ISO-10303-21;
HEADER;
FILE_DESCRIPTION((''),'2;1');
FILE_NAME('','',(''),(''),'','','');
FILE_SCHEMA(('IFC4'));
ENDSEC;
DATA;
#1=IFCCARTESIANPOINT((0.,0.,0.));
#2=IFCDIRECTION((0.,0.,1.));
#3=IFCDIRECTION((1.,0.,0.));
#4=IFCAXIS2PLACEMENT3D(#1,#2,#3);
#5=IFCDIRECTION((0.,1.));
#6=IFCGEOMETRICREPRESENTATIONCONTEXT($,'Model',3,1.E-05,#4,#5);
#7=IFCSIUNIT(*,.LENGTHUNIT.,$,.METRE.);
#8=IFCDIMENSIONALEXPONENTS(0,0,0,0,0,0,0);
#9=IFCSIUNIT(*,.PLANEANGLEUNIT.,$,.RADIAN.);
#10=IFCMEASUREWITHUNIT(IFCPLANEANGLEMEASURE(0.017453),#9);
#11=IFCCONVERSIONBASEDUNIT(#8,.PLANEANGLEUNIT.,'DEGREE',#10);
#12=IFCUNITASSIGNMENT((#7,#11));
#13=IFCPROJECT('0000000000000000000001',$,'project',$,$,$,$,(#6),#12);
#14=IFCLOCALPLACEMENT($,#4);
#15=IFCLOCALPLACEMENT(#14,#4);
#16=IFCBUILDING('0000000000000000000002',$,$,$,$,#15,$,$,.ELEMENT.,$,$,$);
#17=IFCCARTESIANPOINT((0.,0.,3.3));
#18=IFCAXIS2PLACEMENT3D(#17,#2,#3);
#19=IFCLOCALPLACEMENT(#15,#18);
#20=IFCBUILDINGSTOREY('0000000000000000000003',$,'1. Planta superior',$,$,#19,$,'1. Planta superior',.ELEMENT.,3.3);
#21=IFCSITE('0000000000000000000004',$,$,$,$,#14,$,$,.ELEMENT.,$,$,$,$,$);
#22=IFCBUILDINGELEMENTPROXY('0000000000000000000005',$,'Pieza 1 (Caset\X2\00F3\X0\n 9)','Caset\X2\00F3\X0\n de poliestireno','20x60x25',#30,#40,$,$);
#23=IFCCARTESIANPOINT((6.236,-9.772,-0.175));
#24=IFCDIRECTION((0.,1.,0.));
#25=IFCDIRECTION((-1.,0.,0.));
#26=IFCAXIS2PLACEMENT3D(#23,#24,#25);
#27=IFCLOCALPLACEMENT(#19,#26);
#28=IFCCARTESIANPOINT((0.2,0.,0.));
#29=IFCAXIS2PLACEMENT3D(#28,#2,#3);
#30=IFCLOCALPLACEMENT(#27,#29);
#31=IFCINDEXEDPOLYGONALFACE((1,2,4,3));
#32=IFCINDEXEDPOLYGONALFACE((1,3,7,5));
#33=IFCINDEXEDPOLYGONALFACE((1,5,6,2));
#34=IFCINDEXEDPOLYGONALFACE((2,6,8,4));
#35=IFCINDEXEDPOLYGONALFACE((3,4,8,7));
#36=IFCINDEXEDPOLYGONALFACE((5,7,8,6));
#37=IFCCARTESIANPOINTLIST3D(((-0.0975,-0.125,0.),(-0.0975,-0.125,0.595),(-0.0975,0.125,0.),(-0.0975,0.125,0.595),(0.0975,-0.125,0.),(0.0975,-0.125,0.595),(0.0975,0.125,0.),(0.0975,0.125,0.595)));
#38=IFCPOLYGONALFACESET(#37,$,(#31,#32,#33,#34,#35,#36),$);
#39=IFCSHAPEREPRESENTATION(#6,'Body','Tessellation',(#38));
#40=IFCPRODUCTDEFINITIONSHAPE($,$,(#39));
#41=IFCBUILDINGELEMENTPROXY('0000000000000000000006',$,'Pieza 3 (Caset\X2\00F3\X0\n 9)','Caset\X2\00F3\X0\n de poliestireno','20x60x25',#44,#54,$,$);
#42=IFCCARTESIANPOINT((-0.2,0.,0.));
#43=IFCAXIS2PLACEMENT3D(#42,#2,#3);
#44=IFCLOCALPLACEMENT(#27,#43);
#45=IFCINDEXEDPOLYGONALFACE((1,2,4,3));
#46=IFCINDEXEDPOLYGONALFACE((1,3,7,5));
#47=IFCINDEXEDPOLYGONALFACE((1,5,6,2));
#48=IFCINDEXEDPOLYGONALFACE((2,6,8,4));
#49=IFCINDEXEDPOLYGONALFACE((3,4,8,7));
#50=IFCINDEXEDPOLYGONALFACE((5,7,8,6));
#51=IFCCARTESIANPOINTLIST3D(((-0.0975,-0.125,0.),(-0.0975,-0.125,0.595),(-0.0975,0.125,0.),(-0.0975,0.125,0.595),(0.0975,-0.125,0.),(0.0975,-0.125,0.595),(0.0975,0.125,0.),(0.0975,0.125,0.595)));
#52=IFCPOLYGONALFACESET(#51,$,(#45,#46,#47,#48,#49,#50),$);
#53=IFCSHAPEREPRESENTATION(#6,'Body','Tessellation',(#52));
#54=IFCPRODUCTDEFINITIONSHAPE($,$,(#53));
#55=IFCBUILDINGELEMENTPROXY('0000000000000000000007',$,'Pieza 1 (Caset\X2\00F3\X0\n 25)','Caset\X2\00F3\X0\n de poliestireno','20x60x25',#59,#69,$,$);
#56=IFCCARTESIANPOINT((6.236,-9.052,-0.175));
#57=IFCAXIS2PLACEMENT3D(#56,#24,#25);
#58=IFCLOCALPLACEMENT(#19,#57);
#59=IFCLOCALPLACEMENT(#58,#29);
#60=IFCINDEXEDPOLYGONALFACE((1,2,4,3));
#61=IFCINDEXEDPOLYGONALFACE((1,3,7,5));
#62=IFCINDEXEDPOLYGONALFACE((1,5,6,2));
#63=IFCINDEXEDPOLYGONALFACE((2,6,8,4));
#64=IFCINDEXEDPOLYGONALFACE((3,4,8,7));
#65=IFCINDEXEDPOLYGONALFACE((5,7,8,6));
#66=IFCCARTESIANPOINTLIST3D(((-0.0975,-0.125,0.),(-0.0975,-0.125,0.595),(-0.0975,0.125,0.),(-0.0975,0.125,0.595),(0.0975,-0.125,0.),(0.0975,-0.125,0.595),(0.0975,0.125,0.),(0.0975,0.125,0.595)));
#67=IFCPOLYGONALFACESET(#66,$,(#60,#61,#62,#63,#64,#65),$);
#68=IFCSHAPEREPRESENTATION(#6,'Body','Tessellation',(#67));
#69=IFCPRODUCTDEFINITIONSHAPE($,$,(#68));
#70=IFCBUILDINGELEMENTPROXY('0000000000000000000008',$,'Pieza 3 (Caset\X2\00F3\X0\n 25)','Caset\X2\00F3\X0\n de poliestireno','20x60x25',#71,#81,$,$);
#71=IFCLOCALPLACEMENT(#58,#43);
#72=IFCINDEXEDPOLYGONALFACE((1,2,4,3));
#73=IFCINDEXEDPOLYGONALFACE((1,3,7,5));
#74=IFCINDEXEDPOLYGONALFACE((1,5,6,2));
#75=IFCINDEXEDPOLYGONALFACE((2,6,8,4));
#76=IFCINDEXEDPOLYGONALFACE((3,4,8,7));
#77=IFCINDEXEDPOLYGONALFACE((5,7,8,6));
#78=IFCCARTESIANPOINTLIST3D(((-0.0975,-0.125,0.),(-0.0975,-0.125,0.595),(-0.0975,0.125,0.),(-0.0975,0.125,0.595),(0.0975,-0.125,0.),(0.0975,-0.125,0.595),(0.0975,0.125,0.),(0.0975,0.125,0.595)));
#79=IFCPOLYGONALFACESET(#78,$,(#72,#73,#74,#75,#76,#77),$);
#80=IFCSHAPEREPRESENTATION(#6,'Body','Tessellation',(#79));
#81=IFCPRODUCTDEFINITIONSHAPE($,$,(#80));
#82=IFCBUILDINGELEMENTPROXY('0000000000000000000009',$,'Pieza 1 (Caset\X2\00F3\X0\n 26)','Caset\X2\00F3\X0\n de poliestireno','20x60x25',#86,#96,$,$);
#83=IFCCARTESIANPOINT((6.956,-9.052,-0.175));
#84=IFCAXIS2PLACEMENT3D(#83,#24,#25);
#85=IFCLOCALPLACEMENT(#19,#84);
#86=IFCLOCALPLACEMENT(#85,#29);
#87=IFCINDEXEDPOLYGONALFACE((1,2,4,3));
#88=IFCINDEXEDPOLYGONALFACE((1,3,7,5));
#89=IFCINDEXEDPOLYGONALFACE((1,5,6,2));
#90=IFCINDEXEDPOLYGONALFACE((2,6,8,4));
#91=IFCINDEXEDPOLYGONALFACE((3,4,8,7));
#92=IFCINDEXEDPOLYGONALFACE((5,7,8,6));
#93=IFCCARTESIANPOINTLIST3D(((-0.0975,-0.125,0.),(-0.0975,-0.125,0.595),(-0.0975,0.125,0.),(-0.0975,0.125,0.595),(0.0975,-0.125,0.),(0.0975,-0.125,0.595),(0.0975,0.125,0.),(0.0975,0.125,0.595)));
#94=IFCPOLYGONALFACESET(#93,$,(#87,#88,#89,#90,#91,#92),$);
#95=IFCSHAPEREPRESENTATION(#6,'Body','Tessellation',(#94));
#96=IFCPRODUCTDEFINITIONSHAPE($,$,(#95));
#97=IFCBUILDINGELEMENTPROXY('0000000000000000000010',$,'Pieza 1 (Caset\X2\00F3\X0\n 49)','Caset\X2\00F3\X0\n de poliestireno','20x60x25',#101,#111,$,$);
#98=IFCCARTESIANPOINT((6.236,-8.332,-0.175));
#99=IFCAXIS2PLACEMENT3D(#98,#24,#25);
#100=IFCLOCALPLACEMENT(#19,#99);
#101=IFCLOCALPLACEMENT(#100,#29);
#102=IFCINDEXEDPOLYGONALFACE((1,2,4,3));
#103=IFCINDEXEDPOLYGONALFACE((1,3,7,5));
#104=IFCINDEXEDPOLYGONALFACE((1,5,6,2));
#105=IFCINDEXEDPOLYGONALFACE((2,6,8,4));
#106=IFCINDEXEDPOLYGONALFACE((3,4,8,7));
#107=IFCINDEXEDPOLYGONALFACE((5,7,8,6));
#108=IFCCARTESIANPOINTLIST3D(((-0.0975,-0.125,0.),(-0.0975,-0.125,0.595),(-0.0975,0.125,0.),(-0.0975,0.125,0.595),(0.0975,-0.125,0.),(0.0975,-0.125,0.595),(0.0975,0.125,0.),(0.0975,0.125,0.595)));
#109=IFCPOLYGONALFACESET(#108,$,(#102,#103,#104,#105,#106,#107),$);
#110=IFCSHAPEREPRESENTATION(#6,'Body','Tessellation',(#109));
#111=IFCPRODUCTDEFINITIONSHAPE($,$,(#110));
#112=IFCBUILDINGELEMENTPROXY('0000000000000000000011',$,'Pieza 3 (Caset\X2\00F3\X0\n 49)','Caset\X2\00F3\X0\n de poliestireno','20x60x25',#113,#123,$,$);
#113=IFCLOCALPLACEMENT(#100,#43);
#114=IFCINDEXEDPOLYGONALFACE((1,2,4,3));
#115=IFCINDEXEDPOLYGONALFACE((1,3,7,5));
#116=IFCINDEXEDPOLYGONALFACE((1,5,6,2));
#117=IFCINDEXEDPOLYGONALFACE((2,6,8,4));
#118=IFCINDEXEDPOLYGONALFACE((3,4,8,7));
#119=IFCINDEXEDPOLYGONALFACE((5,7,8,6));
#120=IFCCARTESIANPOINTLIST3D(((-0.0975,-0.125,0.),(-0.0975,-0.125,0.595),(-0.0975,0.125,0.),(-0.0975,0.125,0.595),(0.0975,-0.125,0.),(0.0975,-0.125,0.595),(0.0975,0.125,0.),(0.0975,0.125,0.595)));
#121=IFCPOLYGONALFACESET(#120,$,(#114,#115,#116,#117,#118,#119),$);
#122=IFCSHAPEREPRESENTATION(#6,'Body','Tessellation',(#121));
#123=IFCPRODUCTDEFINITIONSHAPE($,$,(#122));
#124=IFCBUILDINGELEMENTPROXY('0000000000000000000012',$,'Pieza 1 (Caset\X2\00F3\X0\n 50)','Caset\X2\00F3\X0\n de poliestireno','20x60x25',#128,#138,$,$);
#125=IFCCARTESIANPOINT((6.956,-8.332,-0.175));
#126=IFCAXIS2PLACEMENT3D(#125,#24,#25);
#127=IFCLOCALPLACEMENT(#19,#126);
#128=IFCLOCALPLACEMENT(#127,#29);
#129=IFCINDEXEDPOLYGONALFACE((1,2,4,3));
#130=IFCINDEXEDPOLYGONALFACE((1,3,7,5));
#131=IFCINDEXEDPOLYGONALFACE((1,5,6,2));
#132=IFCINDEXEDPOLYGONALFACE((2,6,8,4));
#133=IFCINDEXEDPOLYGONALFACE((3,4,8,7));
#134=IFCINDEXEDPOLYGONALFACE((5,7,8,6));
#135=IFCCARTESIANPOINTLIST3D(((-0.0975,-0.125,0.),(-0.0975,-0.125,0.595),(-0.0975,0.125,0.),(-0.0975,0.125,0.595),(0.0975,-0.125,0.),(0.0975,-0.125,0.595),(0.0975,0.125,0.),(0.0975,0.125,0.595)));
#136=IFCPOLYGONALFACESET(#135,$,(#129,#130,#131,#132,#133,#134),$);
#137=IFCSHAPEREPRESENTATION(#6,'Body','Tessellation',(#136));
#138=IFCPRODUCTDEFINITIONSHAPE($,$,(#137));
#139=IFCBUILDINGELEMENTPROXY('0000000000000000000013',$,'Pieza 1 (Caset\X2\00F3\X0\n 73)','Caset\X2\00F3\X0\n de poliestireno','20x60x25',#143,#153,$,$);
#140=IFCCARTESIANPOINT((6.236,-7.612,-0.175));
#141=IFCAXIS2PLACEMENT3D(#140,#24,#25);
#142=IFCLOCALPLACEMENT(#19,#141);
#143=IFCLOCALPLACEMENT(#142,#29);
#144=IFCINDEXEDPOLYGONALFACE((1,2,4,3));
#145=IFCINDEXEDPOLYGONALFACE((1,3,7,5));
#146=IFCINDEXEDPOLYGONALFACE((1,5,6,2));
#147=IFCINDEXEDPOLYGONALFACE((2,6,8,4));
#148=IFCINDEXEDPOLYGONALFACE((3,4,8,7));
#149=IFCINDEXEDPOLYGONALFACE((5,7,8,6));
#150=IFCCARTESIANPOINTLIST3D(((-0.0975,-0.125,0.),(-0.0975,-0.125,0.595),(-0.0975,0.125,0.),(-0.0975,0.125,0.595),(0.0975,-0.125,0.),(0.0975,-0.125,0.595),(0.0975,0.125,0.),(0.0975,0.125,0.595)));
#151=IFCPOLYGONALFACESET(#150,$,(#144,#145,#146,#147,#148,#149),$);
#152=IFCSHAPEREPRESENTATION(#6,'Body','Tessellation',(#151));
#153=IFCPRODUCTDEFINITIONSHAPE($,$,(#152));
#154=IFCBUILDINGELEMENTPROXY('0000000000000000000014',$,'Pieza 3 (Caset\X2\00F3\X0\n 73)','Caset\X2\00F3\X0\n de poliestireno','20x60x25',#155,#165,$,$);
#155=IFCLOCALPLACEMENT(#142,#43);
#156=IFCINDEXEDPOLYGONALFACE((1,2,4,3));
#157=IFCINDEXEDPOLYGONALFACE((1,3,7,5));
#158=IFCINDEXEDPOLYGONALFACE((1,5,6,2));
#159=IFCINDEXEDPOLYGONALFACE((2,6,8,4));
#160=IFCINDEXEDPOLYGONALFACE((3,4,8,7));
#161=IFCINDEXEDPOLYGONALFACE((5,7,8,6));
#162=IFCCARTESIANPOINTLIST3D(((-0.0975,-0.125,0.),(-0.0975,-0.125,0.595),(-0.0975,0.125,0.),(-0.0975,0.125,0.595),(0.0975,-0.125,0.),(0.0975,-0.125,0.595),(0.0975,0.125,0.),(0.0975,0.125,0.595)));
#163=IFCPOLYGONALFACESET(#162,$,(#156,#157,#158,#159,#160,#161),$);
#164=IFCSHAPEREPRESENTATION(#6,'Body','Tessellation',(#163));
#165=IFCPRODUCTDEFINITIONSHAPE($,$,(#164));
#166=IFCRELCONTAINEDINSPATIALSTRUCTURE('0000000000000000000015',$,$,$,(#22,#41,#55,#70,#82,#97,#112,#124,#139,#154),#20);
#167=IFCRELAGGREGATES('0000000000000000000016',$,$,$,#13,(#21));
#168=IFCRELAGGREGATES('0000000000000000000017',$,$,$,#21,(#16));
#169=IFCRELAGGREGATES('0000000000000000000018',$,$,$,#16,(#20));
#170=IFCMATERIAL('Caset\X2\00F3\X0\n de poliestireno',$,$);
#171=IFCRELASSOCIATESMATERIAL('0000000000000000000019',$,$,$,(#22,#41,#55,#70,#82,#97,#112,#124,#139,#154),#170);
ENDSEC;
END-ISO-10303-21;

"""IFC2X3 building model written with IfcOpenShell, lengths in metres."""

from ifc_helpers import new_model, entity, si_unit, converted_unit, direction, frame, origin_with_axes, origin_2d_with_axis, place, context, project, spatial, rectangle, extrude, source, transform, mapped, material, element, save


model = new_model("IFC2X3")

# Units and contexts
model_context = context("Model", 3, precision=1e-05, world=origin_with_axes(), true_north=direction((0.0, 1.0)))
ifc_project = project(units=[si_unit("LENGTHUNIT", "METRE"), converted_unit("PLANEANGLEUNIT", "DEGREE", entity("IfcPlaneAngleMeasure", 0.017453), si_unit("PLANEANGLEUNIT", "RADIAN"), dimensions=[0, 0, 0, 0, 0, 0, 0])], contexts=[model_context])

# Site, building, storey
site_placement = place(None, origin_with_axes())
site = spatial("IfcSite", under=ifc_project, at=site_placement, CompositionType="ELEMENT")
building_placement = place(site_placement, origin_with_axes())
building = spatial("IfcBuilding", under=site, at=building_placement, CompositionType="ELEMENT")
storey_placement = place(building_placement, frame((0.0, 0.0, 3.3), z_axis=(0.0, 0.0, 1.0), x_axis=(1.0, 0.0, 0.0)))
storey = spatial("IfcBuildingStorey", under=building, at=storey_placement, Name="1. Planta superior", LongName="1. Planta superior", CompositionType="ELEMENT", Elevation=3.3)

# Building element proxies
ifc_material = material(Name="Casetón de poliestireno")
shared_shape = source(origin_with_axes(), model_context, "Body", "SweptSolid", [
    extrude(rectangle(XDim=0.195, YDim=0.25, at=origin_2d_with_axis()), origin_with_axes(), (0.0, 0.0, 1.0), 0.595),
])
placement_1 = place(storey_placement, frame((6.236, -9.772, -0.175), z_axis=(0.0, 1.0, 0.0), x_axis=(-1.0, 0.0, 0.0)))
for number, where, z_axis, x_axis, name in (
    (1, (0.2, 0.0, 0.0), (0.0, 0.0, 1.0), (1.0, 0.0, 0.0), "Pieza 1 (Casetón 9)"),
    (2, (-0.2, 0.0, 0.0), (0.0, 0.0, 1.0), (1.0, 0.0, 0.0), "Pieza 3 (Casetón 9)"),
):
    element("IfcBuildingElementProxy", number, at=place(placement_1, frame(where, z_axis=z_axis, x_axis=x_axis)), inside=storey, material=ifc_material, Name=name, Description="Casetón de poliestireno", ObjectType="20x60x25", context=model_context, shape_type="MappedRepresentation", body=[
        mapped(shared_shape, transform((0.0, 0.0, 0.0), x_axis=(1.0, 0.0, 0.0), y_axis=(0.0, 1.0, 0.0), z_axis=(0.0, 0.0, 1.0))),
    ])
placement_2 = place(storey_placement, frame((6.236, -9.052, -0.175), z_axis=(0.0, 1.0, 0.0), x_axis=(-1.0, 0.0, 0.0)))
for number, where, z_axis, x_axis, name in (
    (3, (0.2, 0.0, 0.0), (0.0, 0.0, 1.0), (1.0, 0.0, 0.0), "Pieza 1 (Casetón 25)"),
    (4, (-0.2, 0.0, 0.0), (0.0, 0.0, 1.0), (1.0, 0.0, 0.0), "Pieza 3 (Casetón 25)"),
):
    element("IfcBuildingElementProxy", number, at=place(placement_2, frame(where, z_axis=z_axis, x_axis=x_axis)), inside=storey, material=ifc_material, Name=name, Description="Casetón de poliestireno", ObjectType="20x60x25", context=model_context, shape_type="MappedRepresentation", body=[
        mapped(shared_shape, transform((0.0, 0.0, 0.0), x_axis=(1.0, 0.0, 0.0), y_axis=(0.0, 1.0, 0.0), z_axis=(0.0, 0.0, 1.0))),
    ])
placement_3 = place(storey_placement, frame((6.956, -9.052, -0.175), z_axis=(0.0, 1.0, 0.0), x_axis=(-1.0, 0.0, 0.0)))
for number, where, z_axis, x_axis, name in (
    (5, (0.2, 0.0, 0.0), (0.0, 0.0, 1.0), (1.0, 0.0, 0.0), "Pieza 1 (Casetón 26)"),
):
    element("IfcBuildingElementProxy", number, at=place(placement_3, frame(where, z_axis=z_axis, x_axis=x_axis)), inside=storey, material=ifc_material, Name=name, Description="Casetón de poliestireno", ObjectType="20x60x25", context=model_context, shape_type="MappedRepresentation", body=[
        mapped(shared_shape, transform((0.0, 0.0, 0.0), x_axis=(1.0, 0.0, 0.0), y_axis=(0.0, 1.0, 0.0), z_axis=(0.0, 0.0, 1.0))),
    ])
placement_4 = place(storey_placement, frame((6.236, -8.332, -0.175), z_axis=(0.0, 1.0, 0.0), x_axis=(-1.0, 0.0, 0.0)))
for number, where, z_axis, x_axis, name in (
    (6, (0.2, 0.0, 0.0), (0.0, 0.0, 1.0), (1.0, 0.0, 0.0), "Pieza 1 (Casetón 49)"),
    (7, (-0.2, 0.0, 0.0), (0.0, 0.0, 1.0), (1.0, 0.0, 0.0), "Pieza 3 (Casetón 49)"),
):
    element("IfcBuildingElementProxy", number, at=place(placement_4, frame(where, z_axis=z_axis, x_axis=x_axis)), inside=storey, material=ifc_material, Name=name, Description="Casetón de poliestireno", ObjectType="20x60x25", context=model_context, shape_type="MappedRepresentation", body=[
        mapped(shared_shape, transform((0.0, 0.0, 0.0), x_axis=(1.0, 0.0, 0.0), y_axis=(0.0, 1.0, 0.0), z_axis=(0.0, 0.0, 1.0))),
    ])
placement_5 = place(storey_placement, frame((6.956, -8.332, -0.175), z_axis=(0.0, 1.0, 0.0), x_axis=(-1.0, 0.0, 0.0)))
for number, where, z_axis, x_axis, name in (
    (8, (0.2, 0.0, 0.0), (0.0, 0.0, 1.0), (1.0, 0.0, 0.0), "Pieza 1 (Casetón 50)"),
):
    element("IfcBuildingElementProxy", number, at=place(placement_5, frame(where, z_axis=z_axis, x_axis=x_axis)), inside=storey, material=ifc_material, Name=name, Description="Casetón de poliestireno", ObjectType="20x60x25", context=model_context, shape_type="MappedRepresentation", body=[
        mapped(shared_shape, transform((0.0, 0.0, 0.0), x_axis=(1.0, 0.0, 0.0), y_axis=(0.0, 1.0, 0.0), z_axis=(0.0, 0.0, 1.0))),
    ])
placement_6 = place(storey_placement, frame((6.236, -7.612, -0.175), z_axis=(0.0, 1.0, 0.0), x_axis=(-1.0, 0.0, 0.0)))
for number, where, z_axis, x_axis, name in (
    (9, (0.2, 0.0, 0.0), (0.0, 0.0, 1.0), (1.0, 0.0, 0.0), "Pieza 1 (Casetón 73)"),
    (10, (-0.2, 0.0, 0.0), (0.0, 0.0, 1.0), (1.0, 0.0, 0.0), "Pieza 3 (Casetón 73)"),
):
    element("IfcBuildingElementProxy", number, at=place(placement_6, frame(where, z_axis=z_axis, x_axis=x_axis)), inside=storey, material=ifc_material, Name=name, Description="Casetón de poliestireno", ObjectType="20x60x25", context=model_context, shape_type="MappedRepresentation", body=[
        mapped(shared_shape, transform((0.0, 0.0, 0.0), x_axis=(1.0, 0.0, 0.0), y_axis=(0.0, 1.0, 0.0), z_axis=(0.0, 0.0, 1.0))),
    ])

save(model, "model.ifc")
